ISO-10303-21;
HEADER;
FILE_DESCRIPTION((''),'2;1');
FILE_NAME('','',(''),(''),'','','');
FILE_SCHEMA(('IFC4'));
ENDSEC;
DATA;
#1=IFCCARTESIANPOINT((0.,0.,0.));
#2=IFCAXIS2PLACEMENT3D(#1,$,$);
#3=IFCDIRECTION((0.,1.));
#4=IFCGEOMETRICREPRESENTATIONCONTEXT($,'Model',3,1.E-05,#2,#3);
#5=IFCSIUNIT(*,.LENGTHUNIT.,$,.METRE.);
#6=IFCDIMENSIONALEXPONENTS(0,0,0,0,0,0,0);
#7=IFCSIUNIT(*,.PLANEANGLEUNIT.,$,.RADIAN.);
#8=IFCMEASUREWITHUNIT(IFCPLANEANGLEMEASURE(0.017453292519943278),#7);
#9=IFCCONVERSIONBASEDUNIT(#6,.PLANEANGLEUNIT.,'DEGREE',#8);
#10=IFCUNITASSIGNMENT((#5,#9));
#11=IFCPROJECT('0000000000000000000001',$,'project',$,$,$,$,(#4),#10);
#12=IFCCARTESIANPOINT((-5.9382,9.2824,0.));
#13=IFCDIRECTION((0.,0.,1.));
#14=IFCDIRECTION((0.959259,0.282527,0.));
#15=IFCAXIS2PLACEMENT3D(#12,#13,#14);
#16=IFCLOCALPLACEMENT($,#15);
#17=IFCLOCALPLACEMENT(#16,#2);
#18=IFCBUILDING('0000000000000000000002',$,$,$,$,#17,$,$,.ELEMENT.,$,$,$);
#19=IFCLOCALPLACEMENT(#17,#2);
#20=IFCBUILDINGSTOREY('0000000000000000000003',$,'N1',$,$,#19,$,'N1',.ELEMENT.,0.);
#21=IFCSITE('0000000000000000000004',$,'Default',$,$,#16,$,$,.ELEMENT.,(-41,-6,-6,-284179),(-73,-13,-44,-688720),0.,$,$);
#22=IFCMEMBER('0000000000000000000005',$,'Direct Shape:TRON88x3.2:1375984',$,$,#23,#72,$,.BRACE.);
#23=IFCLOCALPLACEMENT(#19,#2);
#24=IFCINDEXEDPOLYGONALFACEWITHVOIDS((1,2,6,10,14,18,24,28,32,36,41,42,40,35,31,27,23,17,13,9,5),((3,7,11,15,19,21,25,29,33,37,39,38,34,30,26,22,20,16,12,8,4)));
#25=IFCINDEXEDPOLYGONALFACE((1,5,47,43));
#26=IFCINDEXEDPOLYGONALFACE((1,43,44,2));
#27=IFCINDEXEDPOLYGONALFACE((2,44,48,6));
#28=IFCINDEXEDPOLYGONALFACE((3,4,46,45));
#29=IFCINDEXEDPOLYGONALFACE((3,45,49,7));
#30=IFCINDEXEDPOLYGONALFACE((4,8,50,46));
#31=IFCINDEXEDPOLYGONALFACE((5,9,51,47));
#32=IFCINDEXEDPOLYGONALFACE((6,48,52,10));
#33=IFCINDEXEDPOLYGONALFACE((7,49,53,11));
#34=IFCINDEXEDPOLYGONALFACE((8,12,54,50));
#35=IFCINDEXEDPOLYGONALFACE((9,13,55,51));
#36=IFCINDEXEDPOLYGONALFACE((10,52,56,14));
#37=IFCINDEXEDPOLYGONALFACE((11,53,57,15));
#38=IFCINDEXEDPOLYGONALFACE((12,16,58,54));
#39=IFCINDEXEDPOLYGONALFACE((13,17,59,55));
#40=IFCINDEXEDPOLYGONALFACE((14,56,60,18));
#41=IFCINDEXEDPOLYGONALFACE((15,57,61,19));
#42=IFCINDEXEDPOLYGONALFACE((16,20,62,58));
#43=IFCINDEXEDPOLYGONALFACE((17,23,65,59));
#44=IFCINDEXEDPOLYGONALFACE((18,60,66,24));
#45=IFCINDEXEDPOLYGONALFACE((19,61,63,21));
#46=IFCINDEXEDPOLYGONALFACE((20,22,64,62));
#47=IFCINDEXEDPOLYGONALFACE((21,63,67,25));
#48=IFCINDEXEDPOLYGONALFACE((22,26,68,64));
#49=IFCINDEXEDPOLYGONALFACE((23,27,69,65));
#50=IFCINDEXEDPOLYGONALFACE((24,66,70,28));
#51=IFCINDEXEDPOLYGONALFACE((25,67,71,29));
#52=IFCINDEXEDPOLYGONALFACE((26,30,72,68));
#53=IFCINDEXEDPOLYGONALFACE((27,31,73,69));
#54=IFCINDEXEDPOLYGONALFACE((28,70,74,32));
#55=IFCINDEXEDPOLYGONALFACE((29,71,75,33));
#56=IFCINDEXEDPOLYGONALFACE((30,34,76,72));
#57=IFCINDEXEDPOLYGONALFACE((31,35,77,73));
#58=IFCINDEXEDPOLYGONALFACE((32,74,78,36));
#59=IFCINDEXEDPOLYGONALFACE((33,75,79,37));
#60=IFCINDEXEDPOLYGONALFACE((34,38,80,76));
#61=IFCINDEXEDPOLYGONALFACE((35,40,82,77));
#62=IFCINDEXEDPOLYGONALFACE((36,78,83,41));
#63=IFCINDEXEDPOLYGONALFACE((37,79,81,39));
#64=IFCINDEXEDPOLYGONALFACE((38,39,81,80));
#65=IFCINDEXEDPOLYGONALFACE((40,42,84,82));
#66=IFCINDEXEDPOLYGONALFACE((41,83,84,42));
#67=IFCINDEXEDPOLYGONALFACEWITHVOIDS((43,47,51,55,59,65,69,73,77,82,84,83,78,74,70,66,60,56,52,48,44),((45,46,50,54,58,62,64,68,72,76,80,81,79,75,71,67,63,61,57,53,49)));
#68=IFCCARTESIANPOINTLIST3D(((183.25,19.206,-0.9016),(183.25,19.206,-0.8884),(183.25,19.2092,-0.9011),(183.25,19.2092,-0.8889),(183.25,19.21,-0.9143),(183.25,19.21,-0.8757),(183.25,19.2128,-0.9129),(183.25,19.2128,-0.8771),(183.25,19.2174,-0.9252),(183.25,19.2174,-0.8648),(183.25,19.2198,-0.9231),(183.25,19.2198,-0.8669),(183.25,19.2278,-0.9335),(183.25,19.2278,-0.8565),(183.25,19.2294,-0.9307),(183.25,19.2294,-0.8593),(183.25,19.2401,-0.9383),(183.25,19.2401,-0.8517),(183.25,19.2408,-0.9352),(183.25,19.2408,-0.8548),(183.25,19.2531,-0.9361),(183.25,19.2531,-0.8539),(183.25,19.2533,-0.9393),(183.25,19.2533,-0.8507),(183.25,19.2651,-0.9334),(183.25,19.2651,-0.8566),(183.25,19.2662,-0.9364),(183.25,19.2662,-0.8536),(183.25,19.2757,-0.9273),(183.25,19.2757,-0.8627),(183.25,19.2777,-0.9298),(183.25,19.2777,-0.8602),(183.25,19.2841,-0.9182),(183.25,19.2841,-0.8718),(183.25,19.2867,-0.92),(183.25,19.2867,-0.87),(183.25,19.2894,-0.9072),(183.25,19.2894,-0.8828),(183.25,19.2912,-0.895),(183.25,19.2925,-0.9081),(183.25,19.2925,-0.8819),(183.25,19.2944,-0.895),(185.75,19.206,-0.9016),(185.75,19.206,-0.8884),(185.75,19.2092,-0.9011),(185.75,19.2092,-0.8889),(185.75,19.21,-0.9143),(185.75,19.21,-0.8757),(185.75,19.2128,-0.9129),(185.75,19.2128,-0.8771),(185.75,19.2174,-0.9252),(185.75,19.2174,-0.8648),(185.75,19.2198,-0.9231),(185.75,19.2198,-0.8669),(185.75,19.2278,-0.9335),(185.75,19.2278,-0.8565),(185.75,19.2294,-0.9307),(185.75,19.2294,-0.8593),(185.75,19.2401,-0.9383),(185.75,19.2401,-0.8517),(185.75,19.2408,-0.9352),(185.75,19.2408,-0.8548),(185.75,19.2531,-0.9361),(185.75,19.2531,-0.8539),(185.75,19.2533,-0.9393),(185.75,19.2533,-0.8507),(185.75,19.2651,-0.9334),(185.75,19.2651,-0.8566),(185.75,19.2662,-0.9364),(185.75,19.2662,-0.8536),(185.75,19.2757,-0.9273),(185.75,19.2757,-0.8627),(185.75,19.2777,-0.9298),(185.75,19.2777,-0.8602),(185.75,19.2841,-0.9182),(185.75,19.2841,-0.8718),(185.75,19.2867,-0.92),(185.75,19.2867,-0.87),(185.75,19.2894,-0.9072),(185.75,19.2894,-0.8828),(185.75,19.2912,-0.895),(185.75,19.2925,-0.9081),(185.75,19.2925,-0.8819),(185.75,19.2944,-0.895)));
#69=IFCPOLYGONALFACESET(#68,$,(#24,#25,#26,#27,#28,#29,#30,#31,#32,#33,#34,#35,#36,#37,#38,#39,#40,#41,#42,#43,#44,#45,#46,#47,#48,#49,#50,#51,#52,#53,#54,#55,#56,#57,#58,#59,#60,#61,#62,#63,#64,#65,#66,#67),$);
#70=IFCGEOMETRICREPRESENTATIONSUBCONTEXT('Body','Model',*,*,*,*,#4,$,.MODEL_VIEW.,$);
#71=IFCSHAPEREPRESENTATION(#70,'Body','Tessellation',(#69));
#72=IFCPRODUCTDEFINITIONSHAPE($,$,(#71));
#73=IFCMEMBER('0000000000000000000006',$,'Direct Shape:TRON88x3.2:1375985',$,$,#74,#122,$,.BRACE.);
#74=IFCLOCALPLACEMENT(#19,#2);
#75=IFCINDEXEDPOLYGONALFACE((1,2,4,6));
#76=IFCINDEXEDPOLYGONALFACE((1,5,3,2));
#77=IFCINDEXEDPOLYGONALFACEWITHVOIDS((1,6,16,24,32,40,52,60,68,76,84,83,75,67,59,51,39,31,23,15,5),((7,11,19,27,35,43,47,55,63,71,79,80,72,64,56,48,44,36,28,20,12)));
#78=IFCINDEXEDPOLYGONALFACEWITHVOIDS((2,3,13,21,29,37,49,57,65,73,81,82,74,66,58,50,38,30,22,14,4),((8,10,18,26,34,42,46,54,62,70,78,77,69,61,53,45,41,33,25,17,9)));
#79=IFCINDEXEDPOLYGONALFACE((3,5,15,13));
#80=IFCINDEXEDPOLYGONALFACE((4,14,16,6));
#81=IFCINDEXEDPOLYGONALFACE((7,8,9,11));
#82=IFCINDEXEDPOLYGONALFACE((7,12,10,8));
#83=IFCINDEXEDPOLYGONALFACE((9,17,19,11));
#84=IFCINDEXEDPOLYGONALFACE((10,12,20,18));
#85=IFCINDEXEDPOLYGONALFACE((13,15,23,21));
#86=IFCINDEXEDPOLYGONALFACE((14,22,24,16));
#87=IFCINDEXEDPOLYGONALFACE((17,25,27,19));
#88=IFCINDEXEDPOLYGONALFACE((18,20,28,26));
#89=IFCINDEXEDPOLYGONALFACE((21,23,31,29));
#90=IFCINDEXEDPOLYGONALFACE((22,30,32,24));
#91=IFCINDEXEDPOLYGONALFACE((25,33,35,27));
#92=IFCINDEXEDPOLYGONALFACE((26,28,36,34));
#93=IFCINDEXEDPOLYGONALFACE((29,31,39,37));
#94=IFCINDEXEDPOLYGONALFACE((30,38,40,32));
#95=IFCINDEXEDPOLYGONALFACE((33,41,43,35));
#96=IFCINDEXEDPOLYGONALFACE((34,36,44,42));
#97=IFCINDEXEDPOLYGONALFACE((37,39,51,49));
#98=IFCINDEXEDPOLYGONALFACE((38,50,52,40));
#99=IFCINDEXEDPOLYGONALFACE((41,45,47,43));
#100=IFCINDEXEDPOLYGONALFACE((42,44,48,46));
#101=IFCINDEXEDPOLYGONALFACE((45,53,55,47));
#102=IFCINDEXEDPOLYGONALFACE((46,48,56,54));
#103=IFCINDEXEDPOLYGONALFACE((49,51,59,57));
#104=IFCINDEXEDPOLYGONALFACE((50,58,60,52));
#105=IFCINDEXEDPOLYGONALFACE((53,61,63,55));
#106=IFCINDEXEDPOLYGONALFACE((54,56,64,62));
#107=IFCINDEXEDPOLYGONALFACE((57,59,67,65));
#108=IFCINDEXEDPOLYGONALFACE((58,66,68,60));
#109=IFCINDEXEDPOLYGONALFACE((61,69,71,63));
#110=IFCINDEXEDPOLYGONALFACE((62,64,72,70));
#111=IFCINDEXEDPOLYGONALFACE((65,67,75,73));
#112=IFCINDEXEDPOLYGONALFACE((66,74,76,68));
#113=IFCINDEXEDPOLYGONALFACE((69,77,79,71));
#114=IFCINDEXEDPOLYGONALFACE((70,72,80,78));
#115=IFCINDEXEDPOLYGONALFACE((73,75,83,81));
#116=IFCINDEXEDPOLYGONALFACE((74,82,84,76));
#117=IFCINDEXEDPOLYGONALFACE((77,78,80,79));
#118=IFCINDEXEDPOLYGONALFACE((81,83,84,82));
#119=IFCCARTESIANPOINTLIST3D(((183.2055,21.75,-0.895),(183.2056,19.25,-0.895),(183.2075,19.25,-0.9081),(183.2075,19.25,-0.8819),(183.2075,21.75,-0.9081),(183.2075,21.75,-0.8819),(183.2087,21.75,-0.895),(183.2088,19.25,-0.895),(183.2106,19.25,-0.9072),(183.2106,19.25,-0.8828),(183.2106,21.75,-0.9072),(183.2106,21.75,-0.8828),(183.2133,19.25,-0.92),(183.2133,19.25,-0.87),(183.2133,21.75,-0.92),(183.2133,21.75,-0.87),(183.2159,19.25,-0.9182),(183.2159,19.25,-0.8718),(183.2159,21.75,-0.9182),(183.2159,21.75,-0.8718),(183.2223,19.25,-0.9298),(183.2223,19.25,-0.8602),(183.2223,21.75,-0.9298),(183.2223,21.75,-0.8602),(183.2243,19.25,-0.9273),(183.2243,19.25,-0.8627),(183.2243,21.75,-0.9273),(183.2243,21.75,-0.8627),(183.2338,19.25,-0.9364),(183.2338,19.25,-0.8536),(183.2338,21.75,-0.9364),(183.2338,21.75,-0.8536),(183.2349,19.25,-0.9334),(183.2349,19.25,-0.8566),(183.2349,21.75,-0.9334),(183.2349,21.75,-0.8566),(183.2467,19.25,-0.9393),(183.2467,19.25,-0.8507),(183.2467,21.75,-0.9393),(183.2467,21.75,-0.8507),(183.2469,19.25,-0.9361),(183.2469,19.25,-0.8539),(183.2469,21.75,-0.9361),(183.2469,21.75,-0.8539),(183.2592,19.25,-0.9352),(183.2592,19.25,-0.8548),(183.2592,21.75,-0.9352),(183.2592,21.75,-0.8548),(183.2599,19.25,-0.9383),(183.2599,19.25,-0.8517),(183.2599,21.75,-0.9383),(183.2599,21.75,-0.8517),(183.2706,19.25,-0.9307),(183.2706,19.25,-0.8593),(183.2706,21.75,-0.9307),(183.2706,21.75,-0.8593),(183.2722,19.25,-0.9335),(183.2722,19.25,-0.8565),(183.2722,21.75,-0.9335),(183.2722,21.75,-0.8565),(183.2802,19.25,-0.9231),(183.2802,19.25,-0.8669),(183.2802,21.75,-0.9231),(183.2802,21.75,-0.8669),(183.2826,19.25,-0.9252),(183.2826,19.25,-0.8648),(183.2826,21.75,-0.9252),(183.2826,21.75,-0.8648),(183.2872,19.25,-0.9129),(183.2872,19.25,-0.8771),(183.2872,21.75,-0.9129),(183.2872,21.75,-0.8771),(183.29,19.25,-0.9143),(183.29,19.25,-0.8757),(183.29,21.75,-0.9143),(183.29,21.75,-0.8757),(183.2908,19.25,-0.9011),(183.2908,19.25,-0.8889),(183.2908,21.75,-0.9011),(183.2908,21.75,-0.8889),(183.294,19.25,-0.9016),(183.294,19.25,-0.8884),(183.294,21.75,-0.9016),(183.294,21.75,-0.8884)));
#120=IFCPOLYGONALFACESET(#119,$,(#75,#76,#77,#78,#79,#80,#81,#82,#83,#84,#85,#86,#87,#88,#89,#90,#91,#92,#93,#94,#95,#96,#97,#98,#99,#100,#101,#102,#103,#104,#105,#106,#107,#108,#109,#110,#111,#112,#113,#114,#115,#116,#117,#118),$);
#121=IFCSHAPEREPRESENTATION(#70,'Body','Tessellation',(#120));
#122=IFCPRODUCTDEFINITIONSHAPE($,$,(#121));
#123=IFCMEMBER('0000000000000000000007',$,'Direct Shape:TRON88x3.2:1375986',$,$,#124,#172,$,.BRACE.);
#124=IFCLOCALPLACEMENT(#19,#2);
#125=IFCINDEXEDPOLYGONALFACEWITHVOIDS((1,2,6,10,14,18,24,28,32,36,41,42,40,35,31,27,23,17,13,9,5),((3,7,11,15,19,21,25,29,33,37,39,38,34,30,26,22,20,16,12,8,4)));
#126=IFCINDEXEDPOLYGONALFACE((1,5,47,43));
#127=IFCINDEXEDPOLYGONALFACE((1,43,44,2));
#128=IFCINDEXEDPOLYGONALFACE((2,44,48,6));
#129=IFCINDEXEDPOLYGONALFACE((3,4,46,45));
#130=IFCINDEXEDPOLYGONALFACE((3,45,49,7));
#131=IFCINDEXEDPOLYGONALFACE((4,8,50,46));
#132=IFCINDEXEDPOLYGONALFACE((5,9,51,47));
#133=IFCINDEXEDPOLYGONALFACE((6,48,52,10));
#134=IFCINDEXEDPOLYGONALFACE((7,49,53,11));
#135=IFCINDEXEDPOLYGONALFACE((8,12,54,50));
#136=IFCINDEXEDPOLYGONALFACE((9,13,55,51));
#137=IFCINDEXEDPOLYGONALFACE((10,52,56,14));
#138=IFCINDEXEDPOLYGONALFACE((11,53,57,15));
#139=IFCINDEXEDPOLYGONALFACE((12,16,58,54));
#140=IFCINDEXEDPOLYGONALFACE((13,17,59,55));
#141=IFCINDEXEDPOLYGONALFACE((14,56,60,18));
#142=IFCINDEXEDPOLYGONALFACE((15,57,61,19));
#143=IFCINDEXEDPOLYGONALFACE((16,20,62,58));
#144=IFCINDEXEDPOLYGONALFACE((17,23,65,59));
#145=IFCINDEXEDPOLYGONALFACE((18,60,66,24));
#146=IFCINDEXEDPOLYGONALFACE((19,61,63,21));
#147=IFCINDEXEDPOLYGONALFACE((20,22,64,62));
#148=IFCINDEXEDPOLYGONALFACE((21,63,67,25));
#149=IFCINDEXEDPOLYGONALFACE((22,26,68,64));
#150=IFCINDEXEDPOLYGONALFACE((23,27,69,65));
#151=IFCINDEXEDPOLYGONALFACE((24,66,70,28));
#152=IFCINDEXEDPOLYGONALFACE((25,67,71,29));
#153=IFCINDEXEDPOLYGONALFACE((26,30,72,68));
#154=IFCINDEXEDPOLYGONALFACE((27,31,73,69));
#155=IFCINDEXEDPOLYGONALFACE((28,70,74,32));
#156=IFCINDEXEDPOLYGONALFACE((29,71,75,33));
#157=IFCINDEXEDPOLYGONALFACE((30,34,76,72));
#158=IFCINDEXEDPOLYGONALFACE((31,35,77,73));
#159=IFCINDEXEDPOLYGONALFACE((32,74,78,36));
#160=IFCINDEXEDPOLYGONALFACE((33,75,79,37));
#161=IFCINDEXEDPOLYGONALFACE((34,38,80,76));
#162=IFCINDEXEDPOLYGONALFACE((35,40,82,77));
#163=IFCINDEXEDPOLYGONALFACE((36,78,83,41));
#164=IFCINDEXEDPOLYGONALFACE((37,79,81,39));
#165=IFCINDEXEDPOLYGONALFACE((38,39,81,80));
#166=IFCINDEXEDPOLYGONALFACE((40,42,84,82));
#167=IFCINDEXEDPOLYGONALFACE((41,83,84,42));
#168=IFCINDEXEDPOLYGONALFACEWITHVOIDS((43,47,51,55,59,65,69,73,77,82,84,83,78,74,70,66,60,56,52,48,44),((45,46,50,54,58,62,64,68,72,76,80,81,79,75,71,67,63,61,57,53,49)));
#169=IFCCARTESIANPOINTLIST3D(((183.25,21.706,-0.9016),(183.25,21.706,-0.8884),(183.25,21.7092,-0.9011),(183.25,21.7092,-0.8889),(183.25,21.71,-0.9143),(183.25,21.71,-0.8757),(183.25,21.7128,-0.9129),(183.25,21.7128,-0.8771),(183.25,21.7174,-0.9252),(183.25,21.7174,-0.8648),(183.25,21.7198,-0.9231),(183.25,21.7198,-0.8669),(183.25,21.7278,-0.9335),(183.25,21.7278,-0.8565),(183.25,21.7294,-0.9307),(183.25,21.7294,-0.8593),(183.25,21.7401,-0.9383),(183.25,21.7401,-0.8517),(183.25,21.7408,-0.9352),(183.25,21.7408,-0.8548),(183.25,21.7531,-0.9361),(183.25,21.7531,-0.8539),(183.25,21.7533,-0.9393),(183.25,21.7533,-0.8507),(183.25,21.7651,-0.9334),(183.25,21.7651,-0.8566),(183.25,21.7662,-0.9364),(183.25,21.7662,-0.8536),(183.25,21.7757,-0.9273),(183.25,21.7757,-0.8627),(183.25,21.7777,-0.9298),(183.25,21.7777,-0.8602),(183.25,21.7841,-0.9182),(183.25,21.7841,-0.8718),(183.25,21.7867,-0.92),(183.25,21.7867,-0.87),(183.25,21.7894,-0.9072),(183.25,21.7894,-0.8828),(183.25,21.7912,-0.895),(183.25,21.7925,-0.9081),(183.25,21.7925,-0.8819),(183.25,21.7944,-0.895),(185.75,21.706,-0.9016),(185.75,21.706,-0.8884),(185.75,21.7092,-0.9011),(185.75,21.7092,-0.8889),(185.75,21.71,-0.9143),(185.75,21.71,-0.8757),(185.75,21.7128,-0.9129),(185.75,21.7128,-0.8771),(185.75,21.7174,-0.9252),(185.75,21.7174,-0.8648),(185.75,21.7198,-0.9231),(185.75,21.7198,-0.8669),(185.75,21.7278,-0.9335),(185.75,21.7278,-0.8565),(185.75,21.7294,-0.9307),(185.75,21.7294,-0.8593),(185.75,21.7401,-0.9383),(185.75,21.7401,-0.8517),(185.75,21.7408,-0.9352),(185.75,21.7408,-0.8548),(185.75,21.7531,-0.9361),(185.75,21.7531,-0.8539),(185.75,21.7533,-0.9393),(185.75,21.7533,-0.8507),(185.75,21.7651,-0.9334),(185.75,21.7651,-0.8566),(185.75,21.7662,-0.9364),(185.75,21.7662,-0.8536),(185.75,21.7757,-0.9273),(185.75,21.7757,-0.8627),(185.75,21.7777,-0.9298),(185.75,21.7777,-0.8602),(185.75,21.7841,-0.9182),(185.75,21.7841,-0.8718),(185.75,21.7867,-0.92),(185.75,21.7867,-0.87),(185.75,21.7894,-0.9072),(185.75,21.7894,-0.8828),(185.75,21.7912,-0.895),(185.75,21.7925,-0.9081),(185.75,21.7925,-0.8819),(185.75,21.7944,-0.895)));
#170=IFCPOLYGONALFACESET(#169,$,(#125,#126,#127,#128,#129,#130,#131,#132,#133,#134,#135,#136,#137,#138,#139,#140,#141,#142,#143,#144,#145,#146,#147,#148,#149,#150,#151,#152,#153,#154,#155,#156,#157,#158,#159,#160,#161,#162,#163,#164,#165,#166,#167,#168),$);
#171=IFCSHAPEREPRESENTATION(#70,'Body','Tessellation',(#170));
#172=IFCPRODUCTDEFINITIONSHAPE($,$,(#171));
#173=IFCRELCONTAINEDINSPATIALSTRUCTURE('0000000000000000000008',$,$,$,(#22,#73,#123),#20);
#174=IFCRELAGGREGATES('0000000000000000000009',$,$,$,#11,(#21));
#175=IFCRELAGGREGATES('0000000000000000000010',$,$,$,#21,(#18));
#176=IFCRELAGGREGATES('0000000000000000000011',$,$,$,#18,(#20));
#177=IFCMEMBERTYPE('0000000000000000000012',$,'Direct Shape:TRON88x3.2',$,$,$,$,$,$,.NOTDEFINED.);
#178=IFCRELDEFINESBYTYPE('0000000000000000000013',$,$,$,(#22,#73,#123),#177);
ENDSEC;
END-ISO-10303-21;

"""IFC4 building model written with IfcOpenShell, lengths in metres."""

from ifc_helpers import new_model, entity, si_unit, converted_unit, direction, frame, frame_2d, origin, place, context, subcontext, project, spatial, hollow_circle, extrude, type_object, element, save


model = new_model("IFC4")

# Units and contexts
model_context = context("Model", 3, precision=1e-05, world=origin(), true_north=direction((0.0, 1.0)))
body_context = subcontext(model_context, "Body", "Model", "MODEL_VIEW")
ifc_project = project(units=[si_unit("LENGTHUNIT", "METRE"), converted_unit("PLANEANGLEUNIT", "DEGREE", entity("IfcPlaneAngleMeasure", 0.017453292519943278), si_unit("PLANEANGLEUNIT", "RADIAN"), dimensions=[0, 0, 0, 0, 0, 0, 0])], contexts=[model_context])

# Site, building, storey
site_placement = place(None, frame((-5.9382, 9.2824, 0.0), z_axis=(0.0, 0.0, 1.0), x_axis=(0.959259, 0.282527, 0.0)))
site = spatial("IfcSite", under=ifc_project, at=site_placement, Name="Default", CompositionType="ELEMENT", RefLatitude=(-41, -6, -6, -284179), RefLongitude=(-73, -13, -44, -688720), RefElevation=0.0)
building_placement = place(site_placement, origin())
building = spatial("IfcBuilding", under=site, at=building_placement, CompositionType="ELEMENT")
storey_placement = place(building_placement, origin())
storey = spatial("IfcBuildingStorey", under=building, at=storey_placement, Name="N1", LongName="N1", CompositionType="ELEMENT", Elevation=0.0)

# Members
member_type_1 = type_object("IfcMemberType", Name="Direct Shape:TRON88x3.2", PredefinedType="NOTDEFINED")
member_1_placement = place(storey_placement, origin())
element("IfcMember", 1, at=member_1_placement, inside=storey, type_object=member_type_1, Name="Direct Shape:TRON88x3.2:1375984", PredefinedType="BRACE", context=body_context, shape_type="SweptSolid", body=[
    extrude(hollow_circle(Radius=0.0445, WallThickness=0.0032, at=frame_2d((0.0, 0.0), x_axis=(1.0, 0.0))), frame((183.25, 19.25, -0.895), z_axis=(1.0, 0.0, 0.0), x_axis=(0.0, 1.0, 0.0)), (0.0, 0.0, 1.0), 2.5),
])
member_2_placement = place(storey_placement, origin())
element("IfcMember", 2, at=member_2_placement, inside=storey, type_object=member_type_1, Name="Direct Shape:TRON88x3.2:1375985", PredefinedType="BRACE", context=body_context, shape_type="SweptSolid", body=[
    extrude(hollow_circle(Radius=0.0445, WallThickness=0.0032, at=frame_2d((0.0, 0.0), x_axis=(1.0, 0.0))), frame((183.25, 19.25, -0.895), z_axis=(0.0, 1.0, 0.0), x_axis=(-1.0, 0.0, 0.0)), (0.0, 0.0, 1.0), 2.5),
])
member_3_placement = place(storey_placement, origin())
element("IfcMember", 3, at=member_3_placement, inside=storey, type_object=member_type_1, Name="Direct Shape:TRON88x3.2:1375986", PredefinedType="BRACE", context=body_context, shape_type="SweptSolid", body=[
    extrude(hollow_circle(Radius=0.0445, WallThickness=0.0032, at=frame_2d((0.0, 0.0), x_axis=(1.0, 0.0))), frame((183.25, 21.75, -0.895), z_axis=(1.0, 0.0, 0.0), x_axis=(0.0, 1.0, 0.0)), (0.0, 0.0, 1.0), 2.5),
])

save(model, "model.ifc")
